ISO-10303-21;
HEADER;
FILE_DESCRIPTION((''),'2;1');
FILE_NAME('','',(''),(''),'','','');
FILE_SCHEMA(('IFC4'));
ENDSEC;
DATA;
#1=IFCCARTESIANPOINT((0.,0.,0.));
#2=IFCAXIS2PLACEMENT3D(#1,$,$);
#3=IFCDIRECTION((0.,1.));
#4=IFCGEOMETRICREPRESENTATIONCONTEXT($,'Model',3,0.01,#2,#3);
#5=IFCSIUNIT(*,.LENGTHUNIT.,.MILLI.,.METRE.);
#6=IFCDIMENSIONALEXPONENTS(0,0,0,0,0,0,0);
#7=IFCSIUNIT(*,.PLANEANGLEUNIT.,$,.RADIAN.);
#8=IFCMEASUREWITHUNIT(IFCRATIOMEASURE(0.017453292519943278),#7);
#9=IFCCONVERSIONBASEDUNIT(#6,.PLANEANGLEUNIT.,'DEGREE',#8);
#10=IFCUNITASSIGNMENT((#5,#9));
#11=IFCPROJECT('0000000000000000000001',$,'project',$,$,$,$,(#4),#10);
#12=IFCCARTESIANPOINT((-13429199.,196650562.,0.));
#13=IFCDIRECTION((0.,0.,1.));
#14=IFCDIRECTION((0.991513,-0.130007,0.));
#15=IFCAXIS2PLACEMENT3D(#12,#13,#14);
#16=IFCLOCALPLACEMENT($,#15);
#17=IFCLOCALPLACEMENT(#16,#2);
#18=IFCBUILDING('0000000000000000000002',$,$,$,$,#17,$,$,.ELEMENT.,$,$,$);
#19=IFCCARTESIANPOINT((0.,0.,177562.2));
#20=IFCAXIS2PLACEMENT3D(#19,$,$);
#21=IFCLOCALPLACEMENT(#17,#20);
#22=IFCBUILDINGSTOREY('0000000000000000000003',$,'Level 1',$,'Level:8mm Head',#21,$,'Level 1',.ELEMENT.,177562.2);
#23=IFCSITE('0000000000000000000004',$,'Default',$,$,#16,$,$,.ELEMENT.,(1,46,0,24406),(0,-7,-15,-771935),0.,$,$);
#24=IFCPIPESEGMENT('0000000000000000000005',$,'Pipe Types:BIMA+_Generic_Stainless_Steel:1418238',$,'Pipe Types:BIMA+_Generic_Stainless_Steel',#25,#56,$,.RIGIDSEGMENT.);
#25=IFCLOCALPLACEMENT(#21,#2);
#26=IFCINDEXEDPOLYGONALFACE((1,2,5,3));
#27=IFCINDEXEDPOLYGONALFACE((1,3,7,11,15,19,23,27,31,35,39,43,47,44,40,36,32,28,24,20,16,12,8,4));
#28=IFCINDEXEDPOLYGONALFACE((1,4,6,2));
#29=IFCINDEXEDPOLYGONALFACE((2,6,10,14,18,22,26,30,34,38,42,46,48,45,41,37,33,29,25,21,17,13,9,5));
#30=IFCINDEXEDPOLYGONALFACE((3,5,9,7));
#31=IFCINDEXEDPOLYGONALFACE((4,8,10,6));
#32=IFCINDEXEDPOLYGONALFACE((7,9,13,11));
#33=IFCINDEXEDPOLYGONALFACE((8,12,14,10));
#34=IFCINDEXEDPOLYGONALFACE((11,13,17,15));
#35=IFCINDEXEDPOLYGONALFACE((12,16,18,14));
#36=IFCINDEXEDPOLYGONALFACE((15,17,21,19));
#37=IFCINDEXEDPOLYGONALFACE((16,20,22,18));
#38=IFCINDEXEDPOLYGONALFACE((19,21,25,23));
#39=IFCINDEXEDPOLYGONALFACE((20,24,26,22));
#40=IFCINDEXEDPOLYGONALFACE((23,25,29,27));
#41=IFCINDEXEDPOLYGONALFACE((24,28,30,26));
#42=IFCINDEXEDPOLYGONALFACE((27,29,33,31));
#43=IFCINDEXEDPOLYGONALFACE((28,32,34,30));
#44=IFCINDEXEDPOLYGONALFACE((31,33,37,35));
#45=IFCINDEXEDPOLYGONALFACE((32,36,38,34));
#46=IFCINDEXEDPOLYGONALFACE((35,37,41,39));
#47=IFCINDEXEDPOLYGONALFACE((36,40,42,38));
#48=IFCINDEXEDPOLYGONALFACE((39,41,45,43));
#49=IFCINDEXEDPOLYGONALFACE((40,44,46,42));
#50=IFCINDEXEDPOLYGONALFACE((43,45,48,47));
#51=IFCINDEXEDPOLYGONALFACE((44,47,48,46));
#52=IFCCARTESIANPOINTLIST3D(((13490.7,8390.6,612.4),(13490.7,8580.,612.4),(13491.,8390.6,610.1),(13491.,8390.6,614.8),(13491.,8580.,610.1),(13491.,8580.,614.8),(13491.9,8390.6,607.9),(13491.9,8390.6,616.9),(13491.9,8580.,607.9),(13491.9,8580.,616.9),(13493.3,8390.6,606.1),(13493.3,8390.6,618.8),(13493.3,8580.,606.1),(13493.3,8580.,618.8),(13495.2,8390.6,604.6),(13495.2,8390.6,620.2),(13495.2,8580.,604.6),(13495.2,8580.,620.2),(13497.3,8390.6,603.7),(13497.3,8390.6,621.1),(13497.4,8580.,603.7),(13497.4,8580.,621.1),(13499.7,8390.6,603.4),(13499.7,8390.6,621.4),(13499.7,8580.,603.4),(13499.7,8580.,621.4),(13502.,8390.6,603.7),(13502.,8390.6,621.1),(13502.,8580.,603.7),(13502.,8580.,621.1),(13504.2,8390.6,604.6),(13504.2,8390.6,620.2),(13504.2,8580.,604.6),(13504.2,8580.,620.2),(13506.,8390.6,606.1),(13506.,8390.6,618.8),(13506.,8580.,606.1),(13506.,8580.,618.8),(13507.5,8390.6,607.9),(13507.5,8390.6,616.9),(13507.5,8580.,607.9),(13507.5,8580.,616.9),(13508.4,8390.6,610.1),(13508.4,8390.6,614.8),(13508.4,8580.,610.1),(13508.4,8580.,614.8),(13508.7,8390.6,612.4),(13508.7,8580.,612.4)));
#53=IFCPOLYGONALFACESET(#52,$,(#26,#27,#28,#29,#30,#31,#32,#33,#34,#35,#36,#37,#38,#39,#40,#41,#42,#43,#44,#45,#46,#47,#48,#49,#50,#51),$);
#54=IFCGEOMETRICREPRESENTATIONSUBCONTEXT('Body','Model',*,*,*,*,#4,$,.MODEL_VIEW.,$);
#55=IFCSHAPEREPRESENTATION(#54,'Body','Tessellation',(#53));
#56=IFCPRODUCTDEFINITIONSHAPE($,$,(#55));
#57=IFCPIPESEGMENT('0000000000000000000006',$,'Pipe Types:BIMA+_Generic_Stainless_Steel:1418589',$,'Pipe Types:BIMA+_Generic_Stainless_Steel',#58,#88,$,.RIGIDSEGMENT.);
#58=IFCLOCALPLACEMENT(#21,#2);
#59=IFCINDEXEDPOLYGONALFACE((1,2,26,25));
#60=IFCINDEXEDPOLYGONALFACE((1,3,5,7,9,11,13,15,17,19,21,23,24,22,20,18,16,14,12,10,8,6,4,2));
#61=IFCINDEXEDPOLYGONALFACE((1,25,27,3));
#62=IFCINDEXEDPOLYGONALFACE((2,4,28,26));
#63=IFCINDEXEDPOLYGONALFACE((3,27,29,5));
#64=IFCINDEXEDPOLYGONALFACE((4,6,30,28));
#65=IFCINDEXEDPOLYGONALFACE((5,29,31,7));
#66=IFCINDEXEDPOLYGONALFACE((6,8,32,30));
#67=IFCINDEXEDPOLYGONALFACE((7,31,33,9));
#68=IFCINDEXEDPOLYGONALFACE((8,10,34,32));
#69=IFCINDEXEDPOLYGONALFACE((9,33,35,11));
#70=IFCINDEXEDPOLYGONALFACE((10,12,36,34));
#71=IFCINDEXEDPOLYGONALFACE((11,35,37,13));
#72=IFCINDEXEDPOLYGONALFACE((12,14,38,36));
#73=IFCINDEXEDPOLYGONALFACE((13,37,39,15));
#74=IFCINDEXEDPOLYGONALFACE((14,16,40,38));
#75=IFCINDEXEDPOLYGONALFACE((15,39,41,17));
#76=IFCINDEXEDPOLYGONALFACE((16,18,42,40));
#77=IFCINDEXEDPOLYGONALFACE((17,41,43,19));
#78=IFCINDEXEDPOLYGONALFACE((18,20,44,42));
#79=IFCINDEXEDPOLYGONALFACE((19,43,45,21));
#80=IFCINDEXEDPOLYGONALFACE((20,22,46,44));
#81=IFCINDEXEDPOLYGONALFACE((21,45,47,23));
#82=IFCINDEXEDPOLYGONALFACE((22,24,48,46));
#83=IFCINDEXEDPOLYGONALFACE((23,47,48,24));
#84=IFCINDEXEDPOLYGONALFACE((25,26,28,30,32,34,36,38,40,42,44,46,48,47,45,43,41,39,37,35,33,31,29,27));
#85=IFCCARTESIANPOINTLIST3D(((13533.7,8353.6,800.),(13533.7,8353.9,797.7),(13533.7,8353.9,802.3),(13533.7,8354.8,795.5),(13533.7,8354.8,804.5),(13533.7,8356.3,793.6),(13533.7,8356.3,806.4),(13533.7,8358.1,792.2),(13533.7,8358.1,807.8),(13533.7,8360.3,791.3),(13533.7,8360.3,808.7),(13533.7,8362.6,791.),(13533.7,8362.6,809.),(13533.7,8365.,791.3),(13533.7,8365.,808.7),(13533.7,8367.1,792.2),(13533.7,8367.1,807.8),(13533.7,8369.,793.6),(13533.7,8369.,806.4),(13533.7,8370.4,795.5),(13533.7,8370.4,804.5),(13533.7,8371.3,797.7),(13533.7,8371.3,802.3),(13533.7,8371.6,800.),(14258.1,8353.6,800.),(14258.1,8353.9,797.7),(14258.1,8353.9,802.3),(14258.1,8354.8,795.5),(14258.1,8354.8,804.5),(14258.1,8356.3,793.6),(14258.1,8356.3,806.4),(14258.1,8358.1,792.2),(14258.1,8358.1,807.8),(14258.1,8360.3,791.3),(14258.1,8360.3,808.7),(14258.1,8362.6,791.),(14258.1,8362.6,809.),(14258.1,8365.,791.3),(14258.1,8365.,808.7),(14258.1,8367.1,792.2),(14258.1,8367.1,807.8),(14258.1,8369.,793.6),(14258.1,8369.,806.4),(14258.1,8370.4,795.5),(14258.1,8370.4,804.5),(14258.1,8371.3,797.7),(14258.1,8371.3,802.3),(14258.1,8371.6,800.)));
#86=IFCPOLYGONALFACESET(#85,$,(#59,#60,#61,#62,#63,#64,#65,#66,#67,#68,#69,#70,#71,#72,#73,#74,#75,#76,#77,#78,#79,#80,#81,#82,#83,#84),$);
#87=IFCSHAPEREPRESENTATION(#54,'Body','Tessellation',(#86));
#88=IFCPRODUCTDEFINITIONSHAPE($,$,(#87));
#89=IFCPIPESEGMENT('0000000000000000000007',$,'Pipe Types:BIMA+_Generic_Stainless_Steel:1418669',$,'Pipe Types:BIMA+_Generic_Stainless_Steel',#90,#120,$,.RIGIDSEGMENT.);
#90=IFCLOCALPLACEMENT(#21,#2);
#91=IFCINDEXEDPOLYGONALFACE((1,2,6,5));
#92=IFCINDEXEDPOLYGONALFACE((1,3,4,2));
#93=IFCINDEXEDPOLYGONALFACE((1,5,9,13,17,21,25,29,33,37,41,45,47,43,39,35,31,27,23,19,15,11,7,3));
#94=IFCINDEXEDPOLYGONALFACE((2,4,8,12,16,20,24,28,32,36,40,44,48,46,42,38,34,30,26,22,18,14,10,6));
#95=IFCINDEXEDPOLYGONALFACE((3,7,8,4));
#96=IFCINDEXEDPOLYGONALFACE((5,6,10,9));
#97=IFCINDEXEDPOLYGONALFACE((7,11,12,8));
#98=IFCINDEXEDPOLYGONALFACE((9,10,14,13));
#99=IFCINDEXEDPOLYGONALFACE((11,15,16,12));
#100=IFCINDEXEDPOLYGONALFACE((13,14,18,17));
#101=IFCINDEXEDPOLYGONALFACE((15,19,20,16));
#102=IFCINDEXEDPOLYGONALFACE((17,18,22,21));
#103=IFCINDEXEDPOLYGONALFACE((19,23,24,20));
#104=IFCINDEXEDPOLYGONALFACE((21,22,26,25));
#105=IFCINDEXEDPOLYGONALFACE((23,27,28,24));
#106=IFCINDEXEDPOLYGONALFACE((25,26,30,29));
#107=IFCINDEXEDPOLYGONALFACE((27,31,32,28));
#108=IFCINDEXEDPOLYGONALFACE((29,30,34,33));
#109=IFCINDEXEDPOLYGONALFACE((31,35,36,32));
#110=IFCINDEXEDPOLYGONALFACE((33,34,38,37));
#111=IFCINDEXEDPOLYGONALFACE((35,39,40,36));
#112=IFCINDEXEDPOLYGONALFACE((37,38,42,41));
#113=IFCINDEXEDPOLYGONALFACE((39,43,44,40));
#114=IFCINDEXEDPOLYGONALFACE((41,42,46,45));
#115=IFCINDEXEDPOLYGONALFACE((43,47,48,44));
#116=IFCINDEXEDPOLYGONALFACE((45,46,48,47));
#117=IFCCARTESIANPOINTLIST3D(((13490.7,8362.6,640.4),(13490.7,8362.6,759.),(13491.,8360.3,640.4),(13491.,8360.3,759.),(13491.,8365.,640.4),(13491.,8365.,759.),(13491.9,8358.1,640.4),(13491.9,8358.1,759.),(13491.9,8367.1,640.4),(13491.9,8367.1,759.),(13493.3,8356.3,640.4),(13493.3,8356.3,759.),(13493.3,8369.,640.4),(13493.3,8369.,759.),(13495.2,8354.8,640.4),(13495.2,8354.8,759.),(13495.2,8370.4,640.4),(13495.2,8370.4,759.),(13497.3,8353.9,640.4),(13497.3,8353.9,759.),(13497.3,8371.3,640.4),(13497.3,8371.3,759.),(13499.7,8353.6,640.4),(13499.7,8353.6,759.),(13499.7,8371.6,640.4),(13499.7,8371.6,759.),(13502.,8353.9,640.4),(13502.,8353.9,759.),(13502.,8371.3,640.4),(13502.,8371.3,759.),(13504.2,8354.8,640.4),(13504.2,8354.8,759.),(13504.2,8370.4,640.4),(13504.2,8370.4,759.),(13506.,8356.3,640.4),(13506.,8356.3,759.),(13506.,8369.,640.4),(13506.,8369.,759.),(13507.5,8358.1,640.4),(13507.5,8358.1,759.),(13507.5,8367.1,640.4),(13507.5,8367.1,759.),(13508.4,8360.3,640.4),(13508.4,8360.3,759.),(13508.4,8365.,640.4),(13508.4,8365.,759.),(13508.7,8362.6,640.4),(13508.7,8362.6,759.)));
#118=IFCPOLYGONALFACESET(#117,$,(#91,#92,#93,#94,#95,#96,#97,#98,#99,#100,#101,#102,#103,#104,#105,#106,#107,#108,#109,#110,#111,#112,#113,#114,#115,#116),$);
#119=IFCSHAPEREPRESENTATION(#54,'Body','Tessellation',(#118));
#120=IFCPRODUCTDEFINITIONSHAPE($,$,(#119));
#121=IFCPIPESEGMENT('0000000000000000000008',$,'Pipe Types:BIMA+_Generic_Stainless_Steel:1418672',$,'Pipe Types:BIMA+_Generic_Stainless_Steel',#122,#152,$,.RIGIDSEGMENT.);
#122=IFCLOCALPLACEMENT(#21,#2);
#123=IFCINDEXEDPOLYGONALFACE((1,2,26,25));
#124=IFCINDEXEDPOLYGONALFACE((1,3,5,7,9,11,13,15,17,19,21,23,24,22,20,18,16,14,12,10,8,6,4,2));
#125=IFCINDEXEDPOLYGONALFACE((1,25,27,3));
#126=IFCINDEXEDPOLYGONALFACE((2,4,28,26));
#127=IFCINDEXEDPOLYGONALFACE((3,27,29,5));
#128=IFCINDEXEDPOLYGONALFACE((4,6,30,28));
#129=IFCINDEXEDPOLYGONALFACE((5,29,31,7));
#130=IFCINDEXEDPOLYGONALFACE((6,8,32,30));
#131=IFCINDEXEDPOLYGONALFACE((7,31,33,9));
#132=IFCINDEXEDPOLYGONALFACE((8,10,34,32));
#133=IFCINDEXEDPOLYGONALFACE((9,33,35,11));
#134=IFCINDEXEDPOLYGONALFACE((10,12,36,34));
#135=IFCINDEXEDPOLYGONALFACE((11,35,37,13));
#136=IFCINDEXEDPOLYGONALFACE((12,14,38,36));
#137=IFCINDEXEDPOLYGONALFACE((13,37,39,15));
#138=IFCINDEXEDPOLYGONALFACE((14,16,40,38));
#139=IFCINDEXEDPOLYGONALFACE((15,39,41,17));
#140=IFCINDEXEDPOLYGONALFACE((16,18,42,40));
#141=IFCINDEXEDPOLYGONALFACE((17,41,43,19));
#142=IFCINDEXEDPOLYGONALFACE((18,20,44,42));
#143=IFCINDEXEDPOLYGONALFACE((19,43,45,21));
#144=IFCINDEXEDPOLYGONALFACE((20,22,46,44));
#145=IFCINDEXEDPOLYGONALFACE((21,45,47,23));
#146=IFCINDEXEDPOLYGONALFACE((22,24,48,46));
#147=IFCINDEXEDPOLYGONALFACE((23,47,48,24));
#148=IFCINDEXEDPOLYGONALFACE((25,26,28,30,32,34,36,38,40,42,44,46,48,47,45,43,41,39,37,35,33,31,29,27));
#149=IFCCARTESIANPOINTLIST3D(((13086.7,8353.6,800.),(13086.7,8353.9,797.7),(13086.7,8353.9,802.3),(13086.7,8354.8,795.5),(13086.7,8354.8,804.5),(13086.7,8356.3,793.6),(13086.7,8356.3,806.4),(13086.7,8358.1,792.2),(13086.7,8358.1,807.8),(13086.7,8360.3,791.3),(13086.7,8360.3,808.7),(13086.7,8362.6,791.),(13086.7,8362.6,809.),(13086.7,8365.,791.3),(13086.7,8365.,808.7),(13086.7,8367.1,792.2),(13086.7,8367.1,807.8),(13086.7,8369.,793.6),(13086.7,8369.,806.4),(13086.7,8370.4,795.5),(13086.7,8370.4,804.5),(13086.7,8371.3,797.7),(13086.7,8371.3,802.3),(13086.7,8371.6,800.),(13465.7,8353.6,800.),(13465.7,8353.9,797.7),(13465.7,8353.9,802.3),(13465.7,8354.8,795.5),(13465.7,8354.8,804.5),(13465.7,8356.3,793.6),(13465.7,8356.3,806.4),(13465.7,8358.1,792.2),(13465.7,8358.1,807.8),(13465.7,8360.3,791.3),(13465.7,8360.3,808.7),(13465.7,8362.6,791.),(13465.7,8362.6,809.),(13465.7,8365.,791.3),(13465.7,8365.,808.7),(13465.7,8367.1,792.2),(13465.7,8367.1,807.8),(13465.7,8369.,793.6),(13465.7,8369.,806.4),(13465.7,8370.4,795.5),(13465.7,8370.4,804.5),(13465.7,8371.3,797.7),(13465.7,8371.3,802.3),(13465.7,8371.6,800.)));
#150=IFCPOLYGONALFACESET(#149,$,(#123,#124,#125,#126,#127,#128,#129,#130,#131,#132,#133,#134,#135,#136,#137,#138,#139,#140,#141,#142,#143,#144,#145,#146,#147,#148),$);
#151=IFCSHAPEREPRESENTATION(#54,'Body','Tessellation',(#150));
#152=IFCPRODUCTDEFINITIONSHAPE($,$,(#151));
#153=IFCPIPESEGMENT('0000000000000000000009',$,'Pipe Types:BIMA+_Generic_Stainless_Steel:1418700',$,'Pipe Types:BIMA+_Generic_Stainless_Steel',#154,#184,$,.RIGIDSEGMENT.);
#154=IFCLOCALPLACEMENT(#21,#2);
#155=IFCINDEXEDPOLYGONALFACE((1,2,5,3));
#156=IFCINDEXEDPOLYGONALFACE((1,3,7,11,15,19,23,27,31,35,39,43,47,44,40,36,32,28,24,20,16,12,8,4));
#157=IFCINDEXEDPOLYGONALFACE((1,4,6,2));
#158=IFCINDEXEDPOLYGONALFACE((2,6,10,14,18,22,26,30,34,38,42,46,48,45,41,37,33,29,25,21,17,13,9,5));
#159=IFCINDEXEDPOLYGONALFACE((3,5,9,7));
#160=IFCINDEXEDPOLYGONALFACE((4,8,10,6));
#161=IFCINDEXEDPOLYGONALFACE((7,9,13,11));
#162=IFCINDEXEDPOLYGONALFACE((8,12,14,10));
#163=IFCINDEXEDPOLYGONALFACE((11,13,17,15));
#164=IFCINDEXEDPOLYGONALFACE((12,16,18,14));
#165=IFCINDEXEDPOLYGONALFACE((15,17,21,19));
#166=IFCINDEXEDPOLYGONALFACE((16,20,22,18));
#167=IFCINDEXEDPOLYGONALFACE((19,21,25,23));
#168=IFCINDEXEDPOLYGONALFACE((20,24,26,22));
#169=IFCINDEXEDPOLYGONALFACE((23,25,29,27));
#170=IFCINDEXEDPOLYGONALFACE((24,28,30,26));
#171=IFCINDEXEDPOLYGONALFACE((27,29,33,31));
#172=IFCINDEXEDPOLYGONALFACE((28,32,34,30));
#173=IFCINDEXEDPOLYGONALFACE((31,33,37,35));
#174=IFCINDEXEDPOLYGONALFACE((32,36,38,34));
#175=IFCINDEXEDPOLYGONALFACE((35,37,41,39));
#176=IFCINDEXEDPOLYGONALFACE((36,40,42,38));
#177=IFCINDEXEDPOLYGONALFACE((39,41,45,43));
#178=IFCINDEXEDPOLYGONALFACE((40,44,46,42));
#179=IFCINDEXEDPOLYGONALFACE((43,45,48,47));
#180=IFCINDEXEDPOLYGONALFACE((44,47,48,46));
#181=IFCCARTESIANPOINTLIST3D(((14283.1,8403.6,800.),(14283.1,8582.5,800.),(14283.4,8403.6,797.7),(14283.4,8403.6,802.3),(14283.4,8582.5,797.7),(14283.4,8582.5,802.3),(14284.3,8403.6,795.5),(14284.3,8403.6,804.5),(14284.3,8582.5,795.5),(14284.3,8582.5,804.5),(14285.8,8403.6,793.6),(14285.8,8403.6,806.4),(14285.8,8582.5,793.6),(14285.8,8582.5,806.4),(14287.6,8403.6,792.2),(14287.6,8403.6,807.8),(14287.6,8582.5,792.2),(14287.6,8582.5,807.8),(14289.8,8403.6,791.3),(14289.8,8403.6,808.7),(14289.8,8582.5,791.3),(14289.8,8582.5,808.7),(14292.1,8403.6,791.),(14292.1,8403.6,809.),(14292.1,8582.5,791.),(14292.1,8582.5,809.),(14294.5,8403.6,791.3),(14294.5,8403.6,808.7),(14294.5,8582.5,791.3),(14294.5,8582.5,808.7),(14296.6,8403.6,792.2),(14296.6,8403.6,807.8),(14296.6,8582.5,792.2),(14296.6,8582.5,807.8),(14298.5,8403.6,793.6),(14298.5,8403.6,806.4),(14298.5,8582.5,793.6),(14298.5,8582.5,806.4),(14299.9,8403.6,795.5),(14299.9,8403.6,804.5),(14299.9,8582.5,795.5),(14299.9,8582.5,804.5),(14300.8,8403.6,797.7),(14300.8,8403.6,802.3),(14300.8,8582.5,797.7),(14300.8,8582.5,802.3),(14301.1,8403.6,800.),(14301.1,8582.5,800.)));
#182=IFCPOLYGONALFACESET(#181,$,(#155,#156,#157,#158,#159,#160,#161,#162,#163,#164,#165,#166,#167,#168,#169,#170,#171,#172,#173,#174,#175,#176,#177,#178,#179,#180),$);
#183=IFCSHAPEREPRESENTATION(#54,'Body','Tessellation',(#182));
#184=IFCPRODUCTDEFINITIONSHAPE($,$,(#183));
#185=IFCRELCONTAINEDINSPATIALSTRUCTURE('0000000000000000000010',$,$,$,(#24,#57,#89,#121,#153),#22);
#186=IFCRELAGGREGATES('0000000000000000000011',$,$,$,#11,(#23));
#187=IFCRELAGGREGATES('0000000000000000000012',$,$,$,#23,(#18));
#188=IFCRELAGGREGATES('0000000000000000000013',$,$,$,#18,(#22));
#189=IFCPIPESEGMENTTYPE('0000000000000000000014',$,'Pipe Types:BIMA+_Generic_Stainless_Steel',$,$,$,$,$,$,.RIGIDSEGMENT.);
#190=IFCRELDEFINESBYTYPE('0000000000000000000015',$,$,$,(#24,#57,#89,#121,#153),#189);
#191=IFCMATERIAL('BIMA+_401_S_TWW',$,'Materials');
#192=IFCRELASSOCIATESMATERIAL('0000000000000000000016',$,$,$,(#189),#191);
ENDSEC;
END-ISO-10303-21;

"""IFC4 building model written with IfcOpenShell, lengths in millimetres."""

from ifc_helpers import new_model, entity, si_unit, converted_unit, direction, frame, origin, place, context, subcontext, project, spatial, arc, indexed_curve, outline, extrude, material, type_object, element, save


model = new_model("IFC4")

# Units and contexts
model_context = context("Model", 3, precision=0.01, world=origin(), true_north=direction((0.0, 1.0)))
body_context = subcontext(model_context, "Body", "Model", "MODEL_VIEW")
ifc_project = project(units=[si_unit("LENGTHUNIT", "METRE", prefix="MILLI"), converted_unit("PLANEANGLEUNIT", "DEGREE", entity("IfcRatioMeasure", 0.017453292519943278), si_unit("PLANEANGLEUNIT", "RADIAN"), dimensions=[0, 0, 0, 0, 0, 0, 0])], contexts=[model_context])

# Site, building, storey
site_placement = place(None, frame((-13429199.0, 196650562.0, 0.0), z_axis=(0.0, 0.0, 1.0), x_axis=(0.991513, -0.130007, 0.0)))
site = spatial("IfcSite", under=ifc_project, at=site_placement, Name="Default", CompositionType="ELEMENT", RefLatitude=(1, 46, 0, 24406), RefLongitude=(0, -7, -15, -771935), RefElevation=0.0)
building_placement = place(site_placement, origin())
building = spatial("IfcBuilding", under=site, at=building_placement, CompositionType="ELEMENT")
storey_placement = place(building_placement, frame((0.0, 0.0, 177562.2)))
storey = spatial("IfcBuildingStorey", under=building, at=storey_placement, Name="Level 1", ObjectType="Level:8mm Head", LongName="Level 1", CompositionType="ELEMENT", Elevation=177562.2)

# Pipe segments
ifc_material_1 = material(Name="BIMA+_401_S_TWW", Category="Materials")
pipe_segment_type_1 = type_object("IfcPipeSegmentType", Name="Pipe Types:BIMA+_Generic_Stainless_Steel", PredefinedType="RIGIDSEGMENT", material=ifc_material_1)
pipe_segment_1_placement = place(storey_placement, frame((13489.1, 8390.6, 601.8)))
element("IfcPipeSegment", 1, at=pipe_segment_1_placement, inside=storey, type_object=pipe_segment_type_1, Name="Pipe Types:BIMA+_Generic_Stainless_Steel:1418238", ObjectType="Pipe Types:BIMA+_Generic_Stainless_Steel", PredefinedType="RIGIDSEGMENT", context=body_context, shape_type="SweptSolid", body=[
    extrude(outline(indexed_curve([(9.0, 0.0), (6.4, 6.4), (0.0, 9.0), (-6.4, 6.4), (-9.0, 0.0), (-6.4, -6.4), (0.0, -9.0), (6.4, -6.4)], segments=[arc(1, 2, 3), arc(3, 4, 5), arc(5, 6, 7), arc(7, 8, 1)], self_intersect=False)), frame((10.6, 0.0, 10.6), z_axis=(0.000062, 1.0, 0.0), x_axis=(1.0, -0.000062, 0.0)), (0.0, 0.0, 1.0), 189.4),
])
pipe_segment_2_placement = place(storey_placement, frame((13533.7, 8352.0, 810.6)))
element("IfcPipeSegment", 2, at=pipe_segment_2_placement, inside=storey, type_object=pipe_segment_type_1, Name="Pipe Types:BIMA+_Generic_Stainless_Steel:1418589", ObjectType="Pipe Types:BIMA+_Generic_Stainless_Steel", PredefinedType="RIGIDSEGMENT", context=body_context, shape_type="SweptSolid", body=[
    extrude(outline(indexed_curve([(9.0, 0.0), (6.4, 6.4), (0.0, 9.0), (-6.4, 6.4), (-9.0, 0.0), (-6.4, -6.4), (0.0, -9.0), (6.4, -6.4)], segments=[arc(1, 2, 3), arc(3, 4, 5), arc(5, 6, 7), arc(7, 8, 1)], self_intersect=False)), frame((0.0, 10.6, -10.6), z_axis=(1.0, 0.0, 0.0), x_axis=(0.0, 1.0, 0.0)), (0.0, 0.0, 1.0), 724.5),
])
pipe_segment_3_placement = place(storey_placement, frame((13489.1, 8352.0, 640.4)))
element("IfcPipeSegment", 3, at=pipe_segment_3_placement, inside=storey, type_object=pipe_segment_type_1, Name="Pipe Types:BIMA+_Generic_Stainless_Steel:1418669", ObjectType="Pipe Types:BIMA+_Generic_Stainless_Steel", PredefinedType="RIGIDSEGMENT", context=body_context, shape_type="SweptSolid", body=[
    extrude(outline(indexed_curve([(9.0, 0.0), (6.4, 6.4), (0.0, 9.0), (-6.4, 6.4), (-9.0, 0.0), (-6.4, -6.4), (0.0, -9.0), (6.4, -6.4)], segments=[arc(1, 2, 3), arc(3, 4, 5), arc(5, 6, 7), arc(7, 8, 1)], self_intersect=False)), frame((10.6, 10.6, 0.0)), (0.0, 0.0, 1.0), 118.6),
])
pipe_segment_4_placement = place(storey_placement, frame((13086.7, 8352.0, 789.4)))
element("IfcPipeSegment", 4, at=pipe_segment_4_placement, inside=storey, type_object=pipe_segment_type_1, Name="Pipe Types:BIMA+_Generic_Stainless_Steel:1418672", ObjectType="Pipe Types:BIMA+_Generic_Stainless_Steel", PredefinedType="RIGIDSEGMENT", context=body_context, shape_type="SweptSolid", body=[
    extrude(outline(indexed_curve([(9.0, 0.0), (6.4, 6.4), (0.0, 9.0), (-6.4, 6.4), (-9.0, 0.0), (-6.4, -6.4), (0.0, -9.0), (6.4, -6.4)], segments=[arc(1, 2, 3), arc(3, 4, 5), arc(5, 6, 7), arc(7, 8, 1)], self_intersect=False)), frame((0.0, 10.6, 10.6), z_axis=(1.0, 0.0, 0.0), x_axis=(0.0, -1.0, 0.0)), (0.0, 0.0, 1.0), 379.0),
])
pipe_segment_5_placement = place(storey_placement, frame((14281.5, 8403.6, 789.4)))
element("IfcPipeSegment", 5, at=pipe_segment_5_placement, inside=storey, type_object=pipe_segment_type_1, Name="Pipe Types:BIMA+_Generic_Stainless_Steel:1418700", ObjectType="Pipe Types:BIMA+_Generic_Stainless_Steel", PredefinedType="RIGIDSEGMENT", context=body_context, shape_type="SweptSolid", body=[
    extrude(outline(indexed_curve([(9.0, 0.0), (6.4, 6.4), (0.0, 9.0), (-6.4, 6.4), (-9.0, 0.0), (-6.4, -6.4), (0.0, -9.0), (6.4, -6.4)], segments=[arc(1, 2, 3), arc(3, 4, 5), arc(5, 6, 7), arc(7, 8, 1)], self_intersect=False)), frame((10.6, 0.0, 10.6), z_axis=(0.0, 1.0, 0.0), x_axis=(-1.0, 0.0, 0.0)), (0.0, 0.0, 1.0), 178.8),
])

save(model, "model.ifc")
